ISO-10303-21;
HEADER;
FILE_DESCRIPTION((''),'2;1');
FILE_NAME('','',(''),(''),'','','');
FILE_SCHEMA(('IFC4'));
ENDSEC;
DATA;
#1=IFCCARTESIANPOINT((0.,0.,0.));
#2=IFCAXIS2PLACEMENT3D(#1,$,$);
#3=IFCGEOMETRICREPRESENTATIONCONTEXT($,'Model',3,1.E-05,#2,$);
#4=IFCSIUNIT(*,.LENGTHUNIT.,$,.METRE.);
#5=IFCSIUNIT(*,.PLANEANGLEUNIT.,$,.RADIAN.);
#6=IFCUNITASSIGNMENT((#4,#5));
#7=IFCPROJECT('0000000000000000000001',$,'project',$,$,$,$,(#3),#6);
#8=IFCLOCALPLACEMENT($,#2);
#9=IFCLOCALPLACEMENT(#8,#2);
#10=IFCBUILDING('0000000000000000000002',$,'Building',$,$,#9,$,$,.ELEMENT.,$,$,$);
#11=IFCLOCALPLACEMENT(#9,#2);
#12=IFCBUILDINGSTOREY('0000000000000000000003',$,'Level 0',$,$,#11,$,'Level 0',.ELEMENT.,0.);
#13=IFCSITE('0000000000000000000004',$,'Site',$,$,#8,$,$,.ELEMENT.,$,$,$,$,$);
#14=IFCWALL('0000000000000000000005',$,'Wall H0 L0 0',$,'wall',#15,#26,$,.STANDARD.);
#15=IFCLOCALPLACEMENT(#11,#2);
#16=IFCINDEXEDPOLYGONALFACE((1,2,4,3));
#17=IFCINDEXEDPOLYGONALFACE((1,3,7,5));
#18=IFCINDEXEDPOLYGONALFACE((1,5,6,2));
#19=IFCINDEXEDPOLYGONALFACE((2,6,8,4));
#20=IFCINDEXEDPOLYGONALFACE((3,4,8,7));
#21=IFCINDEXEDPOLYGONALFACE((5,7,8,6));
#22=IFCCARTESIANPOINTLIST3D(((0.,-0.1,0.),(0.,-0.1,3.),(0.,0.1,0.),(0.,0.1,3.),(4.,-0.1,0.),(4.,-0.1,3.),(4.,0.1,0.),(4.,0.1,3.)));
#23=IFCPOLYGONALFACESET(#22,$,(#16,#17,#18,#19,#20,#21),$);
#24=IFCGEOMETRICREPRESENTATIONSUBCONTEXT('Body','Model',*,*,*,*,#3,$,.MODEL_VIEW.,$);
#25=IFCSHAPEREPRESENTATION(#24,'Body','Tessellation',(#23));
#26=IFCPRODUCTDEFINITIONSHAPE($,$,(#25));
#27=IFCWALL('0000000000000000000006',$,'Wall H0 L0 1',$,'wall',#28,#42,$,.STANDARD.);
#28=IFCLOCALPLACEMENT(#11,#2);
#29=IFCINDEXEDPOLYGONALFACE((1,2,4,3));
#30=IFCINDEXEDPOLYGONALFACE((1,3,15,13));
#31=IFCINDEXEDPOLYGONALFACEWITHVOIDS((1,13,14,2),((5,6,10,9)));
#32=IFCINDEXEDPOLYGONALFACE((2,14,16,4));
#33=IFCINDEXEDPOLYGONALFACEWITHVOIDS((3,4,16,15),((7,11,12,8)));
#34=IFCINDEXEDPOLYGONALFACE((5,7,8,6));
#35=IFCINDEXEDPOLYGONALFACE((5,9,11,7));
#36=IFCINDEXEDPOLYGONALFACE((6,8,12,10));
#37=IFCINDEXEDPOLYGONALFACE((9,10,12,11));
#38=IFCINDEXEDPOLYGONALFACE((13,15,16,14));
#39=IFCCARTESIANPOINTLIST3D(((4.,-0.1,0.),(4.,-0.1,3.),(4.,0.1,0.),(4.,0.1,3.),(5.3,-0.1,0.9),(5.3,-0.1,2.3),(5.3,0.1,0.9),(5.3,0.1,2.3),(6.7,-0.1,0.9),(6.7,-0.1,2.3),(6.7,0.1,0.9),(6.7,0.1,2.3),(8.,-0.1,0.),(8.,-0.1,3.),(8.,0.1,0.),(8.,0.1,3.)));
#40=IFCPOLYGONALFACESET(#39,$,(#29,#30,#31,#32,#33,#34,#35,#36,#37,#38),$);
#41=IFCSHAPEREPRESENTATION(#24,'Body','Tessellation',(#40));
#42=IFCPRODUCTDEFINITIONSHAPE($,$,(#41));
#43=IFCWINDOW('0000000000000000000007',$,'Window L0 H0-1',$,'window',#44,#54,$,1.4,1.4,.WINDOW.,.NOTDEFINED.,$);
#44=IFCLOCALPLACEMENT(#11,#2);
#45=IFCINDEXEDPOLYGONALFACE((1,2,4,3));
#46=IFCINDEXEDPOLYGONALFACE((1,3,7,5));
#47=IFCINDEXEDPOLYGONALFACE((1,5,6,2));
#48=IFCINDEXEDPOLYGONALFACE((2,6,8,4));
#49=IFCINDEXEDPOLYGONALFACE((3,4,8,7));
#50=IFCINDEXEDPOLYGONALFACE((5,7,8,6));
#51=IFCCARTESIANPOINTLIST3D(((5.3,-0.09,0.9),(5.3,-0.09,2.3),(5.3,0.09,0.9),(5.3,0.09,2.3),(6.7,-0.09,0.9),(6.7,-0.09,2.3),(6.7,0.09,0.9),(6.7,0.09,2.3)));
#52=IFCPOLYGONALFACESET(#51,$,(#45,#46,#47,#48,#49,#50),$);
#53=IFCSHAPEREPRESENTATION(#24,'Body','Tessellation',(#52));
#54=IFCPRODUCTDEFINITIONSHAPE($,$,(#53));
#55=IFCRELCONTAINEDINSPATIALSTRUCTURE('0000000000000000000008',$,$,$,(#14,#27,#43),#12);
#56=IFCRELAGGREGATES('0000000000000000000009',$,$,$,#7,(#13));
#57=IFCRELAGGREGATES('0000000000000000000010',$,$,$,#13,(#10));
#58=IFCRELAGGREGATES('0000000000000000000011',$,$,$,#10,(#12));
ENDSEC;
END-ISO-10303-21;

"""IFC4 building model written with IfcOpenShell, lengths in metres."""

from ifc_helpers import new_model, si_unit, frame, frame_2d, origin, origin_with_axes, origin_2d, place, context, subcontext, project, spatial, rectangle, extrude, element, fill, save


model = new_model("IFC4")

# Units and contexts
model_context = context("Model", 3, precision=1e-05, world=origin())
body_context = subcontext(model_context, "Body", "Model", "MODEL_VIEW")
ifc_project = project(units=[si_unit("LENGTHUNIT", "METRE"), si_unit("PLANEANGLEUNIT", "RADIAN")], contexts=[model_context])

# Site, building, storey
site_placement = place(None, origin())
site = spatial("IfcSite", under=ifc_project, at=site_placement, Name="Site", CompositionType="ELEMENT")
building_placement = place(site_placement, origin())
building = spatial("IfcBuilding", under=site, at=building_placement, Name="Building", CompositionType="ELEMENT")
storey_placement = place(building_placement, origin())
storey = spatial("IfcBuildingStorey", under=building, at=storey_placement, Name="Level 0", LongName="Level 0", CompositionType="ELEMENT", Elevation=0.0)

# Wall
wall_1_placement = place(storey_placement, origin_with_axes())
element("IfcWall", 1, at=wall_1_placement, inside=storey, Name="Wall H0 L0 0", ObjectType="wall", PredefinedType="STANDARD", context=body_context, shape_type="SweptSolid", body=[
    extrude(rectangle(XDim=4.0, YDim=0.2, at=frame_2d((2.0, 0.0))), origin(), (0.0, 0.0, 1.0), 3.0),
])

# Wall, opening, window
wall_2_placement = place(storey_placement, frame((4.0, 0.0, 0.0), z_axis=(0.0, 0.0, 1.0), x_axis=(1.0, 0.0, 0.0)))
wall_2 = element("IfcWall", 2, at=wall_2_placement, inside=storey, Name="Wall H0 L0 1", ObjectType="wall", PredefinedType="STANDARD", context=body_context, shape_type="SweptSolid", body=[
    extrude(rectangle(XDim=4.0, YDim=0.2, at=frame_2d((2.0, 0.0))), origin(), (0.0, 0.0, 1.0), 3.0),
])
opening_placement = place(storey_placement, frame((6.0, 0.0, 0.9), z_axis=(0.0, 0.0, 1.0), x_axis=(1.0, 0.0, 0.0)))
opening = element("IfcOpeningElement", 3, at=opening_placement, cuts=wall_2, ObjectType="Opening", PredefinedType="OPENING", context=body_context, shape_type="SweptSolid", body=[
    extrude(rectangle(XDim=1.4, YDim=0.22, at=origin_2d()), origin(), (0.0, 0.0, 1.0), 1.4),
])
window_placement = place(storey_placement, frame((6.0, 0.0, 0.9), z_axis=(0.0, 0.0, 1.0), x_axis=(1.0, 0.0, 0.0)))
window = element("IfcWindow", 4, at=window_placement, inside=storey, Name="Window L0 H0-1", ObjectType="window", OverallHeight=1.4, OverallWidth=1.4, PartitioningType="NOTDEFINED", PredefinedType="WINDOW", context=body_context, shape_type="SweptSolid", body=[
    extrude(rectangle(XDim=1.4, YDim=0.18, at=origin_2d()), origin(), (0.0, 0.0, 1.0), 1.4),
])
fill(opening, window)

save(model, "model.ifc")
